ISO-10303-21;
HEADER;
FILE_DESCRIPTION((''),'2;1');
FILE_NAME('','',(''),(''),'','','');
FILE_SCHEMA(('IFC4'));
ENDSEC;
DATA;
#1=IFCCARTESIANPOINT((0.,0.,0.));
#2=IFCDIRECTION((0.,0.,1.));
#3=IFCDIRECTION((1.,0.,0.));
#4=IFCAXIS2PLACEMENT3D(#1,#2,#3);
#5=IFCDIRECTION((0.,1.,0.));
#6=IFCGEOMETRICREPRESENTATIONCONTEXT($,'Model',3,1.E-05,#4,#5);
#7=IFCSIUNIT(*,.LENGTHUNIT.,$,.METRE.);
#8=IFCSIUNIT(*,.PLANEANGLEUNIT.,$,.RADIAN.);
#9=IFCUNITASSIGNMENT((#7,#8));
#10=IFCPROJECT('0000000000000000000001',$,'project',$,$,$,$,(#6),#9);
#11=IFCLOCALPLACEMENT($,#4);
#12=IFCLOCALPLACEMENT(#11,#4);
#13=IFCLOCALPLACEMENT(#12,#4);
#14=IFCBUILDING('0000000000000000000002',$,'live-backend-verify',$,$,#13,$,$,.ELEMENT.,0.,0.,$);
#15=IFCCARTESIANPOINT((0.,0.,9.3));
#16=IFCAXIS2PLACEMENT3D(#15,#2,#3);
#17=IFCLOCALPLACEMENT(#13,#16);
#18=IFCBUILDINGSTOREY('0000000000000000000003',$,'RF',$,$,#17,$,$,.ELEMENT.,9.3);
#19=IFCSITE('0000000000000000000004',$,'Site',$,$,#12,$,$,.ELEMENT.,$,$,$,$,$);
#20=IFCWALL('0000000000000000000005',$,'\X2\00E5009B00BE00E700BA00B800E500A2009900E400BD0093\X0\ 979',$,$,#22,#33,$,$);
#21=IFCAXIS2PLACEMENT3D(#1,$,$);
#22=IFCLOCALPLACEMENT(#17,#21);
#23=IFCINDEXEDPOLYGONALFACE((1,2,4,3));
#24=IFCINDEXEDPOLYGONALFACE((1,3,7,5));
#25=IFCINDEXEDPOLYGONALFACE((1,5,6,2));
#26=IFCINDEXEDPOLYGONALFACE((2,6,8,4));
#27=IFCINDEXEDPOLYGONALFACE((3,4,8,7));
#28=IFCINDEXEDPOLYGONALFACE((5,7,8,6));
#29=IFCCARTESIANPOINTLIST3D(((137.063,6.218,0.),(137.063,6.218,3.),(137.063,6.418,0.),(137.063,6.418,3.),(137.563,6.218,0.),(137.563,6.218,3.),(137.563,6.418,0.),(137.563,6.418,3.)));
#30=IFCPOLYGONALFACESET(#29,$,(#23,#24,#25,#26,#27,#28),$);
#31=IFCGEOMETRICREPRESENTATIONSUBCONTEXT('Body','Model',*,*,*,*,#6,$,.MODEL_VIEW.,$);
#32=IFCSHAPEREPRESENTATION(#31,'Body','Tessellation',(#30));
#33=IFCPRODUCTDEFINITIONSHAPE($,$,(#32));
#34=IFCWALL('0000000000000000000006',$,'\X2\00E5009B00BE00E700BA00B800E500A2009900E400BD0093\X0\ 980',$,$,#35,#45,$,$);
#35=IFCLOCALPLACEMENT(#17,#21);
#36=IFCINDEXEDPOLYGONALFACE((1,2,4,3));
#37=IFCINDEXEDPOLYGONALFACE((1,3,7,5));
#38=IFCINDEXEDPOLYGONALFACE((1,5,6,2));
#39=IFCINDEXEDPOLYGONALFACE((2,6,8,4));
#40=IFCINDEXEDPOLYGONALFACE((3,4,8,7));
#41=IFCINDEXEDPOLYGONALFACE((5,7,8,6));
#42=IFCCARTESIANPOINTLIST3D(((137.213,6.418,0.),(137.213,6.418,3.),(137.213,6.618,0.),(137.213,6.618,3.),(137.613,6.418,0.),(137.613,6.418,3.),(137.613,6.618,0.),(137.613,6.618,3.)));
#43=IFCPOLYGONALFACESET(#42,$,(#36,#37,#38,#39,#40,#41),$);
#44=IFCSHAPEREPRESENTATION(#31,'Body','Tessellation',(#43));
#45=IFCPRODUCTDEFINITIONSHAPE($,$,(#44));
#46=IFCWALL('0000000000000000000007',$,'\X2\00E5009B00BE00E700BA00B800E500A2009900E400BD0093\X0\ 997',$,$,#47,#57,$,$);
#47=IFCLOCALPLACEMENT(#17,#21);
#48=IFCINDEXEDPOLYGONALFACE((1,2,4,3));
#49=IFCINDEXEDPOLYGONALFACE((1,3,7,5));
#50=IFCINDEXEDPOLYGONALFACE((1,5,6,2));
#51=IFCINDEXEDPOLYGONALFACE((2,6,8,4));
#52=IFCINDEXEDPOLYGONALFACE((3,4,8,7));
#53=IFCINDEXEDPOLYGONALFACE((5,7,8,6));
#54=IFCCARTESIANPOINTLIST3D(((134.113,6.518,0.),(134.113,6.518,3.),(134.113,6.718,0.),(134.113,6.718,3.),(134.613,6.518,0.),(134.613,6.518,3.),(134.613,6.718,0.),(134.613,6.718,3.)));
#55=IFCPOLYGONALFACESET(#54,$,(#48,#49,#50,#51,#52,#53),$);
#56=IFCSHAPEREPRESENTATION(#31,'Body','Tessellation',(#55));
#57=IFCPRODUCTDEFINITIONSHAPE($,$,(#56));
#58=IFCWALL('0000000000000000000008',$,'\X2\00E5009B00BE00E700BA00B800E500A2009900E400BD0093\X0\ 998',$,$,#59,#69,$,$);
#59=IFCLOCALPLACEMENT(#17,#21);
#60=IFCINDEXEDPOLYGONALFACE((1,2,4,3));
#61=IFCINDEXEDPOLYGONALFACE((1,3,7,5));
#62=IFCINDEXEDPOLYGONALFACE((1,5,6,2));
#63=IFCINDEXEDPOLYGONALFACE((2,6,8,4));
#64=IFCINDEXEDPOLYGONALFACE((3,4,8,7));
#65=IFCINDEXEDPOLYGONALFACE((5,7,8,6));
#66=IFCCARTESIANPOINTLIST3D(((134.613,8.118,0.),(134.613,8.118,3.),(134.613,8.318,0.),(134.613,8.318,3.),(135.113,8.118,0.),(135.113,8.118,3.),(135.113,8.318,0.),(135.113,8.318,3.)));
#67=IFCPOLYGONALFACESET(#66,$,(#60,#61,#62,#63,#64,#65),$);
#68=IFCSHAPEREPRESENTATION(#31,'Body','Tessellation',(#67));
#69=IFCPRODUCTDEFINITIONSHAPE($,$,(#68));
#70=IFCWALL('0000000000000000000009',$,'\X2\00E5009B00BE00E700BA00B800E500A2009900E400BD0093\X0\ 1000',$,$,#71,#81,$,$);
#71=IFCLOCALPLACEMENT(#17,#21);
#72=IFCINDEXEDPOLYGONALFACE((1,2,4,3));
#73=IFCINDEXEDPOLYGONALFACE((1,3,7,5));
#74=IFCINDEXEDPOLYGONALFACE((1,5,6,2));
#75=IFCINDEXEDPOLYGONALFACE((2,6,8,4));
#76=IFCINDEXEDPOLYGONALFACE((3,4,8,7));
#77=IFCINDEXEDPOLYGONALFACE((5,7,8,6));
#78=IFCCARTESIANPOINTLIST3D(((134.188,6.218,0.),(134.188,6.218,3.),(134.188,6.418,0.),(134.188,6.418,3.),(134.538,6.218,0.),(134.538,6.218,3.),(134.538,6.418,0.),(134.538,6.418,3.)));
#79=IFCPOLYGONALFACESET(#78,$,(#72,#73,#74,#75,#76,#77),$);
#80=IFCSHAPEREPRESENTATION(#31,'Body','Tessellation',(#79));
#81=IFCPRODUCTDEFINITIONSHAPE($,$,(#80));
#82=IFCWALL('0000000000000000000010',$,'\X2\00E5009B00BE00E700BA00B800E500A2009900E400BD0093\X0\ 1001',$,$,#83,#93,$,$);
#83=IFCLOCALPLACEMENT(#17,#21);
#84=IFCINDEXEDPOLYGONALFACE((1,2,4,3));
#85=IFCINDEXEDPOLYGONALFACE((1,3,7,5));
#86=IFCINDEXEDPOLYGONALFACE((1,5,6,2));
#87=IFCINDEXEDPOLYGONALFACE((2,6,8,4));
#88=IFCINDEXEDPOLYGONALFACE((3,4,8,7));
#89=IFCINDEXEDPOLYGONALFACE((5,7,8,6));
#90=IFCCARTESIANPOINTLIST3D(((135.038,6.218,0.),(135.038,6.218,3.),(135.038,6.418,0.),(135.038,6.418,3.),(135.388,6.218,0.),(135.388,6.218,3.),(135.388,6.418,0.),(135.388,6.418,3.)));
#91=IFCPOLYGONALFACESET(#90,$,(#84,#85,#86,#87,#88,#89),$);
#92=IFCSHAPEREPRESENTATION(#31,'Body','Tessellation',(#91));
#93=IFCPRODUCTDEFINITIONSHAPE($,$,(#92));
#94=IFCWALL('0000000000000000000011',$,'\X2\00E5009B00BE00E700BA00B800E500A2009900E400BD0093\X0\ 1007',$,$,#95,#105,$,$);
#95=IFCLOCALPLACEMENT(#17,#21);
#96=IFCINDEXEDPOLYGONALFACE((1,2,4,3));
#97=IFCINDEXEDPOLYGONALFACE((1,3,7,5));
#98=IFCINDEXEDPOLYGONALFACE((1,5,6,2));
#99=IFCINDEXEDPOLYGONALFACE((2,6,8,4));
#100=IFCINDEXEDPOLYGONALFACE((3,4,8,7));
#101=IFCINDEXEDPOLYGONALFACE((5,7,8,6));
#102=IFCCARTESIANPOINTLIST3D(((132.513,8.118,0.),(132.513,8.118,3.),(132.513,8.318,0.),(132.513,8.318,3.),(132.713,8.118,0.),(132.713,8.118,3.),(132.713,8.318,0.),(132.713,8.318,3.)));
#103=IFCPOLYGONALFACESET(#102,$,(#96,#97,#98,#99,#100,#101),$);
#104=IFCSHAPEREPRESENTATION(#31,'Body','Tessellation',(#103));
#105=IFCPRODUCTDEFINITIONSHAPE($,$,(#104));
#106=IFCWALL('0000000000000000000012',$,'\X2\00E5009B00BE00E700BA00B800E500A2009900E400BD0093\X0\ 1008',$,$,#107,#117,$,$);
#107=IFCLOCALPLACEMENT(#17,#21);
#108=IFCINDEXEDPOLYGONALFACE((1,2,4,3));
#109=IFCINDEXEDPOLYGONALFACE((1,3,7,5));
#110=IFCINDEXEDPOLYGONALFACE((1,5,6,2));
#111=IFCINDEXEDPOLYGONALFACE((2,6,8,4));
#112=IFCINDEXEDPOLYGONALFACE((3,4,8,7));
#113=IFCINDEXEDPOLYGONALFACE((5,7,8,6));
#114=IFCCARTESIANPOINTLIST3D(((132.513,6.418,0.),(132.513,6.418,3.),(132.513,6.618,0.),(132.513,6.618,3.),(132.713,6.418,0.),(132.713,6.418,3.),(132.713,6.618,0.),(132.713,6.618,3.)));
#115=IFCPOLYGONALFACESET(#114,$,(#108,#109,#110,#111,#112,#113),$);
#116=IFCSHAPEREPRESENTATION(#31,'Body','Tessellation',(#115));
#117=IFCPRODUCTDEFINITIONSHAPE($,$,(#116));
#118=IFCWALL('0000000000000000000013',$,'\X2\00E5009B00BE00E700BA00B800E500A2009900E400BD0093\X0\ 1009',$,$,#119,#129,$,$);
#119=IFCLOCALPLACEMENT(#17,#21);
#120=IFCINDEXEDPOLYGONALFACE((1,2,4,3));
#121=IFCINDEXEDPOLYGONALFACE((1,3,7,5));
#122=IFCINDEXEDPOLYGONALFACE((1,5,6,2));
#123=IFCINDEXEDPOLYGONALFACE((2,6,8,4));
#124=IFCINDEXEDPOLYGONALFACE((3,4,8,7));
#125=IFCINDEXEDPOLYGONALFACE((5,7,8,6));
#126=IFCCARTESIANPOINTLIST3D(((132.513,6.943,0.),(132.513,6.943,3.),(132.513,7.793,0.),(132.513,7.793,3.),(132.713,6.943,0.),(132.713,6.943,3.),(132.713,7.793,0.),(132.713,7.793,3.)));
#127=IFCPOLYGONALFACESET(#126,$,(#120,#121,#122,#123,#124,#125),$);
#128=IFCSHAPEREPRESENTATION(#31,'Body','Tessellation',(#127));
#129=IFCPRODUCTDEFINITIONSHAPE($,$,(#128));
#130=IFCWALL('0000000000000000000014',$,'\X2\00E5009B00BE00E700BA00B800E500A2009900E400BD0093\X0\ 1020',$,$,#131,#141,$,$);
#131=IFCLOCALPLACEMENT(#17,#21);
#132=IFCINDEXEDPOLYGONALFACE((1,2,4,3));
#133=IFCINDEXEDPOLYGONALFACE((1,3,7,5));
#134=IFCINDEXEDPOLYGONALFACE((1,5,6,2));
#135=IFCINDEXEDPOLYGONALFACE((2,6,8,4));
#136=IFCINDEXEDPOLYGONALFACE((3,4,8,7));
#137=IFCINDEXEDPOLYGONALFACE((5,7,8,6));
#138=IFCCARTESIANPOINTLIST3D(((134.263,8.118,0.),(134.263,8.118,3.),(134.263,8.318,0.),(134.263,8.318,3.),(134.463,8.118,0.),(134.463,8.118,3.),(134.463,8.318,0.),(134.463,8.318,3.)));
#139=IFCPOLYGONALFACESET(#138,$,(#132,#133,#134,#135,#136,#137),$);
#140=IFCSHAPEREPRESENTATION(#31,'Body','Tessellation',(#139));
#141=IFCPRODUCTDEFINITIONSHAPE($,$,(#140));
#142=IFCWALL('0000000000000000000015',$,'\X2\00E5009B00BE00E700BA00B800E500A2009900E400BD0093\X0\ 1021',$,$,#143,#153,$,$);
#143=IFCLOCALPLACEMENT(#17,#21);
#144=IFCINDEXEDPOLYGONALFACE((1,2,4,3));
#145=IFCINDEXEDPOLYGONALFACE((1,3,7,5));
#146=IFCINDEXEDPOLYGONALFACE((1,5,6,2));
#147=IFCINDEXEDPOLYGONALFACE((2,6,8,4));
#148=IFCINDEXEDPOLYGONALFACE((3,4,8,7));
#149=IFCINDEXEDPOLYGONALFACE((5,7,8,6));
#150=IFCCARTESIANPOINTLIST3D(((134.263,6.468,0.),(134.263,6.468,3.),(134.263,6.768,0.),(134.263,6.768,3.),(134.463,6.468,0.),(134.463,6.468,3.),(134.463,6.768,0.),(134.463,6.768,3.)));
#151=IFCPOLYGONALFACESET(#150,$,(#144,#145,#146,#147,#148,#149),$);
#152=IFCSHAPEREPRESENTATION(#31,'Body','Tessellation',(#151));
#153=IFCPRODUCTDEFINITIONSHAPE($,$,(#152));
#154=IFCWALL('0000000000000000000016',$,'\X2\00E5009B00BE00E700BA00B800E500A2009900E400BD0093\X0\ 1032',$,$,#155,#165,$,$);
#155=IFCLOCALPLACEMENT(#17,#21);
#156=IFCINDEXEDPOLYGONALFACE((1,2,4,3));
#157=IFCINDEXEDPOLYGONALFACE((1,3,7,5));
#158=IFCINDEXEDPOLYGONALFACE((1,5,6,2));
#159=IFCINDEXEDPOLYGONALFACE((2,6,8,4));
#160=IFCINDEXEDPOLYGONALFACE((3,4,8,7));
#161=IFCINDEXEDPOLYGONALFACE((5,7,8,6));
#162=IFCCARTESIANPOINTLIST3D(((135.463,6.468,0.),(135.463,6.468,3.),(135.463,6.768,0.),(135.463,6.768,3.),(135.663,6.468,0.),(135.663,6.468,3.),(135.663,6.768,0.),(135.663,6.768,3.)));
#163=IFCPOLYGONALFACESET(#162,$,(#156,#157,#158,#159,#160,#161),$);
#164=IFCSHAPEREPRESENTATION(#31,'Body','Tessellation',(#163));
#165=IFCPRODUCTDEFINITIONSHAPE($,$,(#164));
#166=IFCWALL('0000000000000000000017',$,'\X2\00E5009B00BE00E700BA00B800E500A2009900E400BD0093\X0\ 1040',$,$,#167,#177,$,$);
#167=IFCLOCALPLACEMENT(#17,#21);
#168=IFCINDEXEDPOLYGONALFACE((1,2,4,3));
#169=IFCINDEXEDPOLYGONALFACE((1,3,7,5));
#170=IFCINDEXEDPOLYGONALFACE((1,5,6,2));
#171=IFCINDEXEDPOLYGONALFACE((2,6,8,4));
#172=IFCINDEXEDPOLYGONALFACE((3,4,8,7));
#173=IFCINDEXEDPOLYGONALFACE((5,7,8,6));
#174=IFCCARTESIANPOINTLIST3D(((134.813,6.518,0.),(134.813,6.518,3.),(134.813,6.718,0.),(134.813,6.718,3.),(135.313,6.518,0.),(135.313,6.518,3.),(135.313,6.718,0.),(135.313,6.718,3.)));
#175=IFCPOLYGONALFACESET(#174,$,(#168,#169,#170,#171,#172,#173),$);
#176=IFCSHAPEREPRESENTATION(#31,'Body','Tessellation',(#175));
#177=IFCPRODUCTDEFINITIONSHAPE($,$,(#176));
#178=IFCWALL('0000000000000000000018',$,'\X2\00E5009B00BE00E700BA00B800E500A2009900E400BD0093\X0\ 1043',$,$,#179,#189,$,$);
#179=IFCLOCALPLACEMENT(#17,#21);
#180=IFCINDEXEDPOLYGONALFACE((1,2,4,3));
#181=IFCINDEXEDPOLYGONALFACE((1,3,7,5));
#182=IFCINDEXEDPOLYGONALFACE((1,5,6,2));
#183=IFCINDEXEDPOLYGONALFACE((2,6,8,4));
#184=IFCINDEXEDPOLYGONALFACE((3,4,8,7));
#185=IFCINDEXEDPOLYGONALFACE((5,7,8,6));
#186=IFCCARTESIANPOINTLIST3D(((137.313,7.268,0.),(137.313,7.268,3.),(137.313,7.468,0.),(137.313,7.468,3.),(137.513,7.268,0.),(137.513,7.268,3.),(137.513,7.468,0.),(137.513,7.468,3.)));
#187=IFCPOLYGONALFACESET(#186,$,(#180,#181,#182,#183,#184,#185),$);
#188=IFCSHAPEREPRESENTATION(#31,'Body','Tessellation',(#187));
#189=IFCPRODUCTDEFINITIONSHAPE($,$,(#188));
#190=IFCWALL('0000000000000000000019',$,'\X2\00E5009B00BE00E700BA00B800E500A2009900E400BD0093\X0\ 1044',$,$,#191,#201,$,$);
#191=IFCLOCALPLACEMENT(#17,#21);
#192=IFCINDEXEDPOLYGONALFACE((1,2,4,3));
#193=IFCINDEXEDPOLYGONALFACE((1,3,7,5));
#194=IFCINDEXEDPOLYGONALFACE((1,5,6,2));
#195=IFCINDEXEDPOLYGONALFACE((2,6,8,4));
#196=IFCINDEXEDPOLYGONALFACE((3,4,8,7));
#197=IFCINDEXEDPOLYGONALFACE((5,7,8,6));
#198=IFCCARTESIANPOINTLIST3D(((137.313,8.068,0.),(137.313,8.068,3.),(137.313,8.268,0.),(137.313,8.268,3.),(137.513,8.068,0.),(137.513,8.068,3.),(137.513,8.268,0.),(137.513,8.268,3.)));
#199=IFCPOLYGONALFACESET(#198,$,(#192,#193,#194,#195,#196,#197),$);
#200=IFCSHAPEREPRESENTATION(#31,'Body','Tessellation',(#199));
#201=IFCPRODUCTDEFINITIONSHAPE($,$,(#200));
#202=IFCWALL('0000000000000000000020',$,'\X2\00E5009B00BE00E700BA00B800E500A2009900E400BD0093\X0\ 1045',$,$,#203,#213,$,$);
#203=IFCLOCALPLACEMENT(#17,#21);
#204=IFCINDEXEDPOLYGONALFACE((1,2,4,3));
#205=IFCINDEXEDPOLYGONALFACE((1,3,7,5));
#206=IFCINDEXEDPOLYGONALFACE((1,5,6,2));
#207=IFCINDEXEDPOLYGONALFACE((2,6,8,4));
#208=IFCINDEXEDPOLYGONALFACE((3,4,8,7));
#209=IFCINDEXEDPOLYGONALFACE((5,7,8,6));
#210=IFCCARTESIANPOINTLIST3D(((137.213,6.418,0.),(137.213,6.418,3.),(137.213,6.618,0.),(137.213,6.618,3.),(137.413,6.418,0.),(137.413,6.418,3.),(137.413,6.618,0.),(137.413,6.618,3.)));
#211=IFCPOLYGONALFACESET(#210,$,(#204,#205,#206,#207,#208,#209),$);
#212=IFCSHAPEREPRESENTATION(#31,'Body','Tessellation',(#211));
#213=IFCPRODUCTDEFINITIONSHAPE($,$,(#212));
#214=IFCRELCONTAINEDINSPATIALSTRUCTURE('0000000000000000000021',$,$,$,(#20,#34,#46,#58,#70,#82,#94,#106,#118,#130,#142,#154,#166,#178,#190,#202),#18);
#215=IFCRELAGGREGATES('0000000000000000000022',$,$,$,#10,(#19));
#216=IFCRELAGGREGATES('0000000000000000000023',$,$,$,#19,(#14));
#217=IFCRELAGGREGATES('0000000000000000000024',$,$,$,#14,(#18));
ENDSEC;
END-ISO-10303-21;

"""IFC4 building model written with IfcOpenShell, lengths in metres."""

from ifc_helpers import new_model, si_unit, direction, frame, frame_2d, origin_with_axes, place, context, subcontext, project, spatial, rectangle, extrude, element, save


model = new_model("IFC4")

# Units and contexts
model_context = context("Model", 3, precision=1e-05, world=origin_with_axes(), true_north=direction((0.0, 1.0, 0.0)))
body_context = subcontext(model_context, "Body", "Model", "MODEL_VIEW")
ifc_project = project(units=[si_unit("LENGTHUNIT", "METRE"), si_unit("PLANEANGLEUNIT", "RADIAN")], contexts=[model_context])

# Site, building, storey
placement = place(None, origin_with_axes())
site_placement = place(placement, origin_with_axes())
site = spatial("IfcSite", under=ifc_project, at=site_placement, Name="Site", CompositionType="ELEMENT")
building_placement = place(site_placement, origin_with_axes())
building = spatial("IfcBuilding", under=site, at=building_placement, Name="live-backend-verify", CompositionType="ELEMENT", ElevationOfRefHeight=0.0, ElevationOfTerrain=0.0)
storey_placement = place(building_placement, frame((0.0, 0.0, 9.3), z_axis=(0.0, 0.0, 1.0), x_axis=(1.0, 0.0, 0.0)))
storey = spatial("IfcBuildingStorey", under=building, at=storey_placement, Name="RF", CompositionType="ELEMENT", Elevation=9.3)

# Walls
wall_1_placement = place(storey_placement, frame((137.313, 6.318, 0.0), z_axis=(0.0, 0.0, 1.0), x_axis=(1.0, 0.0, 0.0)))
element("IfcWall", 1, at=wall_1_placement, inside=storey, Name="å\u009b¾çº¸å¢\u0099ä½\u0093 979", context=body_context, shape_type="SweptSolid", body=[
    extrude(rectangle(XDim=0.5, YDim=0.2, at=frame_2d((0.0, 0.0), x_axis=(1.0, 0.0, 0.0))), frame((0.0, 0.0, 0.0), z_axis=(0.0, 0.0, 1.0)), (0.0, 0.0, 1.0), 3.0),
])
wall_2_placement = place(storey_placement, frame((137.413, 6.518, 0.0), z_axis=(0.0, 0.0, 1.0), x_axis=(1.0, 0.0, 0.0)))
element("IfcWall", 2, at=wall_2_placement, inside=storey, Name="å\u009b¾çº¸å¢\u0099ä½\u0093 980", context=body_context, shape_type="SweptSolid", body=[
    extrude(rectangle(XDim=0.4, YDim=0.2, at=frame_2d((0.0, 0.0), x_axis=(1.0, 0.0, 0.0))), frame((0.0, 0.0, 0.0), z_axis=(0.0, 0.0, 1.0)), (0.0, 0.0, 1.0), 3.0),
])
for number, where, z_axis, x_axis, name in (
    (3, (134.363, 6.618, 0.0), (0.0, 0.0, 1.0), (1.0, 0.0, 0.0), "å\u009b¾çº¸å¢\u0099ä½\u0093 997"),
    (4, (134.863, 8.218, 0.0), (0.0, 0.0, 1.0), (-1.0, 0.0, 0.0), "å\u009b¾çº¸å¢\u0099ä½\u0093 998"),
):
    element("IfcWall", number, at=place(storey_placement, frame(where, z_axis=z_axis, x_axis=x_axis)), inside=storey, Name=name, context=body_context, shape_type="SweptSolid", body=[
        extrude(rectangle(XDim=0.5, YDim=0.2, at=frame_2d((0.0, 0.0), x_axis=(1.0, 0.0, 0.0))), frame((0.0, 0.0, 0.0), z_axis=(0.0, 0.0, 1.0)), (0.0, 0.0, 1.0), 3.0),
    ])
for number, where, z_axis, x_axis, name in (
    (5, (134.363, 6.318, 0.0), (0.0, 0.0, 1.0), (1.0, 0.0, 0.0), "å\u009b¾çº¸å¢\u0099ä½\u0093 1000"),
    (6, (135.213, 6.318, 0.0), (0.0, 0.0, 1.0), (1.0, 0.0, 0.0), "å\u009b¾çº¸å¢\u0099ä½\u0093 1001"),
):
    element("IfcWall", number, at=place(storey_placement, frame(where, z_axis=z_axis, x_axis=x_axis)), inside=storey, Name=name, context=body_context, shape_type="SweptSolid", body=[
        extrude(rectangle(XDim=0.35, YDim=0.2, at=frame_2d((0.0, 0.0), x_axis=(1.0, 0.0, 0.0))), frame((0.0, 0.0, 0.0), z_axis=(0.0, 0.0, 1.0)), (0.0, 0.0, 1.0), 3.0),
    ])
for number, where, z_axis, x_axis, name in (
    (7, (132.613, 8.218, 0.0), (0.0, 0.0, 1.0), (0.0, 1.0, 0.0), "å\u009b¾çº¸å¢\u0099ä½\u0093 1007"),
    (8, (132.613, 6.518, 0.0), (0.0, 0.0, 1.0), (0.0, -1.0, 0.0), "å\u009b¾çº¸å¢\u0099ä½\u0093 1008"),
):
    element("IfcWall", number, at=place(storey_placement, frame(where, z_axis=z_axis, x_axis=x_axis)), inside=storey, Name=name, context=body_context, shape_type="SweptSolid", body=[
        extrude(rectangle(XDim=0.2, YDim=0.2, at=frame_2d((0.0, 0.0), x_axis=(1.0, 0.0, 0.0))), frame((0.0, 0.0, 0.0), z_axis=(0.0, 0.0, 1.0)), (0.0, 0.0, 1.0), 3.0),
    ])
wall_3_placement = place(storey_placement, frame((132.613, 7.368, 0.0), z_axis=(0.0, 0.0, 1.0), x_axis=(0.0, -1.0, 0.0)))
element("IfcWall", 9, at=wall_3_placement, inside=storey, Name="å\u009b¾çº¸å¢\u0099ä½\u0093 1009", context=body_context, shape_type="SweptSolid", body=[
    extrude(rectangle(XDim=0.85, YDim=0.2, at=frame_2d((0.0, 0.0), x_axis=(1.0, 0.0, 0.0))), frame((0.0, 0.0, 0.0), z_axis=(0.0, 0.0, 1.0)), (0.0, 0.0, 1.0), 3.0),
])
for number, where, z_axis, x_axis, name in (
    (10, (134.363, 8.218, 0.0), (0.0, 0.0, 1.0), (0.0, 1.0, 0.0), "å\u009b¾çº¸å¢\u0099ä½\u0093 1020"),
):
    element("IfcWall", number, at=place(storey_placement, frame(where, z_axis=z_axis, x_axis=x_axis)), inside=storey, Name=name, context=body_context, shape_type="SweptSolid", body=[
        extrude(rectangle(XDim=0.2, YDim=0.2, at=frame_2d((0.0, 0.0), x_axis=(1.0, 0.0, 0.0))), frame((0.0, 0.0, 0.0), z_axis=(0.0, 0.0, 1.0)), (0.0, 0.0, 1.0), 3.0),
    ])
for number, where, z_axis, x_axis, name in (
    (11, (134.363, 6.618, 0.0), (0.0, 0.0, 1.0), (0.0, -1.0, 0.0), "å\u009b¾çº¸å¢\u0099ä½\u0093 1021"),
    (12, (135.563, 6.618, 0.0), (0.0, 0.0, 1.0), (0.0, -1.0, 0.0), "å\u009b¾çº¸å¢\u0099ä½\u0093 1032"),
):
    element("IfcWall", number, at=place(storey_placement, frame(where, z_axis=z_axis, x_axis=x_axis)), inside=storey, Name=name, context=body_context, shape_type="SweptSolid", body=[
        extrude(rectangle(XDim=0.3, YDim=0.2, at=frame_2d((0.0, 0.0), x_axis=(1.0, 0.0, 0.0))), frame((0.0, 0.0, 0.0), z_axis=(0.0, 0.0, 1.0)), (0.0, 0.0, 1.0), 3.0),
    ])
wall_4_placement = place(storey_placement, frame((135.063, 6.618, 0.0), z_axis=(0.0, 0.0, 1.0), x_axis=(1.0, 0.0, 0.0)))
element("IfcWall", 13, at=wall_4_placement, inside=storey, Name="å\u009b¾çº¸å¢\u0099ä½\u0093 1040", context=body_context, shape_type="SweptSolid", body=[
    extrude(rectangle(XDim=0.5, YDim=0.2, at=frame_2d((0.0, 0.0), x_axis=(1.0, 0.0, 0.0))), frame((0.0, 0.0, 0.0), z_axis=(0.0, 0.0, 1.0)), (0.0, 0.0, 1.0), 3.0),
])
for number, where, z_axis, x_axis, name in (
    (14, (137.413, 7.368, 0.0), (0.0, 0.0, 1.0), (-1.0, 0.0, 0.0), "å\u009b¾çº¸å¢\u0099ä½\u0093 1043"),
    (15, (137.413, 8.168, 0.0), (0.0, 0.0, 1.0), (-1.0, 0.0, 0.0), "å\u009b¾çº¸å¢\u0099ä½\u0093 1044"),
    (16, (137.313, 6.518, 0.0), (0.0, 0.0, 1.0), (0.0, -1.0, 0.0), "å\u009b¾çº¸å¢\u0099ä½\u0093 1045"),
):
    element("IfcWall", number, at=place(storey_placement, frame(where, z_axis=z_axis, x_axis=x_axis)), inside=storey, Name=name, context=body_context, shape_type="SweptSolid", body=[
        extrude(rectangle(XDim=0.2, YDim=0.2, at=frame_2d((0.0, 0.0), x_axis=(1.0, 0.0, 0.0))), frame((0.0, 0.0, 0.0), z_axis=(0.0, 0.0, 1.0)), (0.0, 0.0, 1.0), 3.0),
    ])

save(model, "model.ifc")
